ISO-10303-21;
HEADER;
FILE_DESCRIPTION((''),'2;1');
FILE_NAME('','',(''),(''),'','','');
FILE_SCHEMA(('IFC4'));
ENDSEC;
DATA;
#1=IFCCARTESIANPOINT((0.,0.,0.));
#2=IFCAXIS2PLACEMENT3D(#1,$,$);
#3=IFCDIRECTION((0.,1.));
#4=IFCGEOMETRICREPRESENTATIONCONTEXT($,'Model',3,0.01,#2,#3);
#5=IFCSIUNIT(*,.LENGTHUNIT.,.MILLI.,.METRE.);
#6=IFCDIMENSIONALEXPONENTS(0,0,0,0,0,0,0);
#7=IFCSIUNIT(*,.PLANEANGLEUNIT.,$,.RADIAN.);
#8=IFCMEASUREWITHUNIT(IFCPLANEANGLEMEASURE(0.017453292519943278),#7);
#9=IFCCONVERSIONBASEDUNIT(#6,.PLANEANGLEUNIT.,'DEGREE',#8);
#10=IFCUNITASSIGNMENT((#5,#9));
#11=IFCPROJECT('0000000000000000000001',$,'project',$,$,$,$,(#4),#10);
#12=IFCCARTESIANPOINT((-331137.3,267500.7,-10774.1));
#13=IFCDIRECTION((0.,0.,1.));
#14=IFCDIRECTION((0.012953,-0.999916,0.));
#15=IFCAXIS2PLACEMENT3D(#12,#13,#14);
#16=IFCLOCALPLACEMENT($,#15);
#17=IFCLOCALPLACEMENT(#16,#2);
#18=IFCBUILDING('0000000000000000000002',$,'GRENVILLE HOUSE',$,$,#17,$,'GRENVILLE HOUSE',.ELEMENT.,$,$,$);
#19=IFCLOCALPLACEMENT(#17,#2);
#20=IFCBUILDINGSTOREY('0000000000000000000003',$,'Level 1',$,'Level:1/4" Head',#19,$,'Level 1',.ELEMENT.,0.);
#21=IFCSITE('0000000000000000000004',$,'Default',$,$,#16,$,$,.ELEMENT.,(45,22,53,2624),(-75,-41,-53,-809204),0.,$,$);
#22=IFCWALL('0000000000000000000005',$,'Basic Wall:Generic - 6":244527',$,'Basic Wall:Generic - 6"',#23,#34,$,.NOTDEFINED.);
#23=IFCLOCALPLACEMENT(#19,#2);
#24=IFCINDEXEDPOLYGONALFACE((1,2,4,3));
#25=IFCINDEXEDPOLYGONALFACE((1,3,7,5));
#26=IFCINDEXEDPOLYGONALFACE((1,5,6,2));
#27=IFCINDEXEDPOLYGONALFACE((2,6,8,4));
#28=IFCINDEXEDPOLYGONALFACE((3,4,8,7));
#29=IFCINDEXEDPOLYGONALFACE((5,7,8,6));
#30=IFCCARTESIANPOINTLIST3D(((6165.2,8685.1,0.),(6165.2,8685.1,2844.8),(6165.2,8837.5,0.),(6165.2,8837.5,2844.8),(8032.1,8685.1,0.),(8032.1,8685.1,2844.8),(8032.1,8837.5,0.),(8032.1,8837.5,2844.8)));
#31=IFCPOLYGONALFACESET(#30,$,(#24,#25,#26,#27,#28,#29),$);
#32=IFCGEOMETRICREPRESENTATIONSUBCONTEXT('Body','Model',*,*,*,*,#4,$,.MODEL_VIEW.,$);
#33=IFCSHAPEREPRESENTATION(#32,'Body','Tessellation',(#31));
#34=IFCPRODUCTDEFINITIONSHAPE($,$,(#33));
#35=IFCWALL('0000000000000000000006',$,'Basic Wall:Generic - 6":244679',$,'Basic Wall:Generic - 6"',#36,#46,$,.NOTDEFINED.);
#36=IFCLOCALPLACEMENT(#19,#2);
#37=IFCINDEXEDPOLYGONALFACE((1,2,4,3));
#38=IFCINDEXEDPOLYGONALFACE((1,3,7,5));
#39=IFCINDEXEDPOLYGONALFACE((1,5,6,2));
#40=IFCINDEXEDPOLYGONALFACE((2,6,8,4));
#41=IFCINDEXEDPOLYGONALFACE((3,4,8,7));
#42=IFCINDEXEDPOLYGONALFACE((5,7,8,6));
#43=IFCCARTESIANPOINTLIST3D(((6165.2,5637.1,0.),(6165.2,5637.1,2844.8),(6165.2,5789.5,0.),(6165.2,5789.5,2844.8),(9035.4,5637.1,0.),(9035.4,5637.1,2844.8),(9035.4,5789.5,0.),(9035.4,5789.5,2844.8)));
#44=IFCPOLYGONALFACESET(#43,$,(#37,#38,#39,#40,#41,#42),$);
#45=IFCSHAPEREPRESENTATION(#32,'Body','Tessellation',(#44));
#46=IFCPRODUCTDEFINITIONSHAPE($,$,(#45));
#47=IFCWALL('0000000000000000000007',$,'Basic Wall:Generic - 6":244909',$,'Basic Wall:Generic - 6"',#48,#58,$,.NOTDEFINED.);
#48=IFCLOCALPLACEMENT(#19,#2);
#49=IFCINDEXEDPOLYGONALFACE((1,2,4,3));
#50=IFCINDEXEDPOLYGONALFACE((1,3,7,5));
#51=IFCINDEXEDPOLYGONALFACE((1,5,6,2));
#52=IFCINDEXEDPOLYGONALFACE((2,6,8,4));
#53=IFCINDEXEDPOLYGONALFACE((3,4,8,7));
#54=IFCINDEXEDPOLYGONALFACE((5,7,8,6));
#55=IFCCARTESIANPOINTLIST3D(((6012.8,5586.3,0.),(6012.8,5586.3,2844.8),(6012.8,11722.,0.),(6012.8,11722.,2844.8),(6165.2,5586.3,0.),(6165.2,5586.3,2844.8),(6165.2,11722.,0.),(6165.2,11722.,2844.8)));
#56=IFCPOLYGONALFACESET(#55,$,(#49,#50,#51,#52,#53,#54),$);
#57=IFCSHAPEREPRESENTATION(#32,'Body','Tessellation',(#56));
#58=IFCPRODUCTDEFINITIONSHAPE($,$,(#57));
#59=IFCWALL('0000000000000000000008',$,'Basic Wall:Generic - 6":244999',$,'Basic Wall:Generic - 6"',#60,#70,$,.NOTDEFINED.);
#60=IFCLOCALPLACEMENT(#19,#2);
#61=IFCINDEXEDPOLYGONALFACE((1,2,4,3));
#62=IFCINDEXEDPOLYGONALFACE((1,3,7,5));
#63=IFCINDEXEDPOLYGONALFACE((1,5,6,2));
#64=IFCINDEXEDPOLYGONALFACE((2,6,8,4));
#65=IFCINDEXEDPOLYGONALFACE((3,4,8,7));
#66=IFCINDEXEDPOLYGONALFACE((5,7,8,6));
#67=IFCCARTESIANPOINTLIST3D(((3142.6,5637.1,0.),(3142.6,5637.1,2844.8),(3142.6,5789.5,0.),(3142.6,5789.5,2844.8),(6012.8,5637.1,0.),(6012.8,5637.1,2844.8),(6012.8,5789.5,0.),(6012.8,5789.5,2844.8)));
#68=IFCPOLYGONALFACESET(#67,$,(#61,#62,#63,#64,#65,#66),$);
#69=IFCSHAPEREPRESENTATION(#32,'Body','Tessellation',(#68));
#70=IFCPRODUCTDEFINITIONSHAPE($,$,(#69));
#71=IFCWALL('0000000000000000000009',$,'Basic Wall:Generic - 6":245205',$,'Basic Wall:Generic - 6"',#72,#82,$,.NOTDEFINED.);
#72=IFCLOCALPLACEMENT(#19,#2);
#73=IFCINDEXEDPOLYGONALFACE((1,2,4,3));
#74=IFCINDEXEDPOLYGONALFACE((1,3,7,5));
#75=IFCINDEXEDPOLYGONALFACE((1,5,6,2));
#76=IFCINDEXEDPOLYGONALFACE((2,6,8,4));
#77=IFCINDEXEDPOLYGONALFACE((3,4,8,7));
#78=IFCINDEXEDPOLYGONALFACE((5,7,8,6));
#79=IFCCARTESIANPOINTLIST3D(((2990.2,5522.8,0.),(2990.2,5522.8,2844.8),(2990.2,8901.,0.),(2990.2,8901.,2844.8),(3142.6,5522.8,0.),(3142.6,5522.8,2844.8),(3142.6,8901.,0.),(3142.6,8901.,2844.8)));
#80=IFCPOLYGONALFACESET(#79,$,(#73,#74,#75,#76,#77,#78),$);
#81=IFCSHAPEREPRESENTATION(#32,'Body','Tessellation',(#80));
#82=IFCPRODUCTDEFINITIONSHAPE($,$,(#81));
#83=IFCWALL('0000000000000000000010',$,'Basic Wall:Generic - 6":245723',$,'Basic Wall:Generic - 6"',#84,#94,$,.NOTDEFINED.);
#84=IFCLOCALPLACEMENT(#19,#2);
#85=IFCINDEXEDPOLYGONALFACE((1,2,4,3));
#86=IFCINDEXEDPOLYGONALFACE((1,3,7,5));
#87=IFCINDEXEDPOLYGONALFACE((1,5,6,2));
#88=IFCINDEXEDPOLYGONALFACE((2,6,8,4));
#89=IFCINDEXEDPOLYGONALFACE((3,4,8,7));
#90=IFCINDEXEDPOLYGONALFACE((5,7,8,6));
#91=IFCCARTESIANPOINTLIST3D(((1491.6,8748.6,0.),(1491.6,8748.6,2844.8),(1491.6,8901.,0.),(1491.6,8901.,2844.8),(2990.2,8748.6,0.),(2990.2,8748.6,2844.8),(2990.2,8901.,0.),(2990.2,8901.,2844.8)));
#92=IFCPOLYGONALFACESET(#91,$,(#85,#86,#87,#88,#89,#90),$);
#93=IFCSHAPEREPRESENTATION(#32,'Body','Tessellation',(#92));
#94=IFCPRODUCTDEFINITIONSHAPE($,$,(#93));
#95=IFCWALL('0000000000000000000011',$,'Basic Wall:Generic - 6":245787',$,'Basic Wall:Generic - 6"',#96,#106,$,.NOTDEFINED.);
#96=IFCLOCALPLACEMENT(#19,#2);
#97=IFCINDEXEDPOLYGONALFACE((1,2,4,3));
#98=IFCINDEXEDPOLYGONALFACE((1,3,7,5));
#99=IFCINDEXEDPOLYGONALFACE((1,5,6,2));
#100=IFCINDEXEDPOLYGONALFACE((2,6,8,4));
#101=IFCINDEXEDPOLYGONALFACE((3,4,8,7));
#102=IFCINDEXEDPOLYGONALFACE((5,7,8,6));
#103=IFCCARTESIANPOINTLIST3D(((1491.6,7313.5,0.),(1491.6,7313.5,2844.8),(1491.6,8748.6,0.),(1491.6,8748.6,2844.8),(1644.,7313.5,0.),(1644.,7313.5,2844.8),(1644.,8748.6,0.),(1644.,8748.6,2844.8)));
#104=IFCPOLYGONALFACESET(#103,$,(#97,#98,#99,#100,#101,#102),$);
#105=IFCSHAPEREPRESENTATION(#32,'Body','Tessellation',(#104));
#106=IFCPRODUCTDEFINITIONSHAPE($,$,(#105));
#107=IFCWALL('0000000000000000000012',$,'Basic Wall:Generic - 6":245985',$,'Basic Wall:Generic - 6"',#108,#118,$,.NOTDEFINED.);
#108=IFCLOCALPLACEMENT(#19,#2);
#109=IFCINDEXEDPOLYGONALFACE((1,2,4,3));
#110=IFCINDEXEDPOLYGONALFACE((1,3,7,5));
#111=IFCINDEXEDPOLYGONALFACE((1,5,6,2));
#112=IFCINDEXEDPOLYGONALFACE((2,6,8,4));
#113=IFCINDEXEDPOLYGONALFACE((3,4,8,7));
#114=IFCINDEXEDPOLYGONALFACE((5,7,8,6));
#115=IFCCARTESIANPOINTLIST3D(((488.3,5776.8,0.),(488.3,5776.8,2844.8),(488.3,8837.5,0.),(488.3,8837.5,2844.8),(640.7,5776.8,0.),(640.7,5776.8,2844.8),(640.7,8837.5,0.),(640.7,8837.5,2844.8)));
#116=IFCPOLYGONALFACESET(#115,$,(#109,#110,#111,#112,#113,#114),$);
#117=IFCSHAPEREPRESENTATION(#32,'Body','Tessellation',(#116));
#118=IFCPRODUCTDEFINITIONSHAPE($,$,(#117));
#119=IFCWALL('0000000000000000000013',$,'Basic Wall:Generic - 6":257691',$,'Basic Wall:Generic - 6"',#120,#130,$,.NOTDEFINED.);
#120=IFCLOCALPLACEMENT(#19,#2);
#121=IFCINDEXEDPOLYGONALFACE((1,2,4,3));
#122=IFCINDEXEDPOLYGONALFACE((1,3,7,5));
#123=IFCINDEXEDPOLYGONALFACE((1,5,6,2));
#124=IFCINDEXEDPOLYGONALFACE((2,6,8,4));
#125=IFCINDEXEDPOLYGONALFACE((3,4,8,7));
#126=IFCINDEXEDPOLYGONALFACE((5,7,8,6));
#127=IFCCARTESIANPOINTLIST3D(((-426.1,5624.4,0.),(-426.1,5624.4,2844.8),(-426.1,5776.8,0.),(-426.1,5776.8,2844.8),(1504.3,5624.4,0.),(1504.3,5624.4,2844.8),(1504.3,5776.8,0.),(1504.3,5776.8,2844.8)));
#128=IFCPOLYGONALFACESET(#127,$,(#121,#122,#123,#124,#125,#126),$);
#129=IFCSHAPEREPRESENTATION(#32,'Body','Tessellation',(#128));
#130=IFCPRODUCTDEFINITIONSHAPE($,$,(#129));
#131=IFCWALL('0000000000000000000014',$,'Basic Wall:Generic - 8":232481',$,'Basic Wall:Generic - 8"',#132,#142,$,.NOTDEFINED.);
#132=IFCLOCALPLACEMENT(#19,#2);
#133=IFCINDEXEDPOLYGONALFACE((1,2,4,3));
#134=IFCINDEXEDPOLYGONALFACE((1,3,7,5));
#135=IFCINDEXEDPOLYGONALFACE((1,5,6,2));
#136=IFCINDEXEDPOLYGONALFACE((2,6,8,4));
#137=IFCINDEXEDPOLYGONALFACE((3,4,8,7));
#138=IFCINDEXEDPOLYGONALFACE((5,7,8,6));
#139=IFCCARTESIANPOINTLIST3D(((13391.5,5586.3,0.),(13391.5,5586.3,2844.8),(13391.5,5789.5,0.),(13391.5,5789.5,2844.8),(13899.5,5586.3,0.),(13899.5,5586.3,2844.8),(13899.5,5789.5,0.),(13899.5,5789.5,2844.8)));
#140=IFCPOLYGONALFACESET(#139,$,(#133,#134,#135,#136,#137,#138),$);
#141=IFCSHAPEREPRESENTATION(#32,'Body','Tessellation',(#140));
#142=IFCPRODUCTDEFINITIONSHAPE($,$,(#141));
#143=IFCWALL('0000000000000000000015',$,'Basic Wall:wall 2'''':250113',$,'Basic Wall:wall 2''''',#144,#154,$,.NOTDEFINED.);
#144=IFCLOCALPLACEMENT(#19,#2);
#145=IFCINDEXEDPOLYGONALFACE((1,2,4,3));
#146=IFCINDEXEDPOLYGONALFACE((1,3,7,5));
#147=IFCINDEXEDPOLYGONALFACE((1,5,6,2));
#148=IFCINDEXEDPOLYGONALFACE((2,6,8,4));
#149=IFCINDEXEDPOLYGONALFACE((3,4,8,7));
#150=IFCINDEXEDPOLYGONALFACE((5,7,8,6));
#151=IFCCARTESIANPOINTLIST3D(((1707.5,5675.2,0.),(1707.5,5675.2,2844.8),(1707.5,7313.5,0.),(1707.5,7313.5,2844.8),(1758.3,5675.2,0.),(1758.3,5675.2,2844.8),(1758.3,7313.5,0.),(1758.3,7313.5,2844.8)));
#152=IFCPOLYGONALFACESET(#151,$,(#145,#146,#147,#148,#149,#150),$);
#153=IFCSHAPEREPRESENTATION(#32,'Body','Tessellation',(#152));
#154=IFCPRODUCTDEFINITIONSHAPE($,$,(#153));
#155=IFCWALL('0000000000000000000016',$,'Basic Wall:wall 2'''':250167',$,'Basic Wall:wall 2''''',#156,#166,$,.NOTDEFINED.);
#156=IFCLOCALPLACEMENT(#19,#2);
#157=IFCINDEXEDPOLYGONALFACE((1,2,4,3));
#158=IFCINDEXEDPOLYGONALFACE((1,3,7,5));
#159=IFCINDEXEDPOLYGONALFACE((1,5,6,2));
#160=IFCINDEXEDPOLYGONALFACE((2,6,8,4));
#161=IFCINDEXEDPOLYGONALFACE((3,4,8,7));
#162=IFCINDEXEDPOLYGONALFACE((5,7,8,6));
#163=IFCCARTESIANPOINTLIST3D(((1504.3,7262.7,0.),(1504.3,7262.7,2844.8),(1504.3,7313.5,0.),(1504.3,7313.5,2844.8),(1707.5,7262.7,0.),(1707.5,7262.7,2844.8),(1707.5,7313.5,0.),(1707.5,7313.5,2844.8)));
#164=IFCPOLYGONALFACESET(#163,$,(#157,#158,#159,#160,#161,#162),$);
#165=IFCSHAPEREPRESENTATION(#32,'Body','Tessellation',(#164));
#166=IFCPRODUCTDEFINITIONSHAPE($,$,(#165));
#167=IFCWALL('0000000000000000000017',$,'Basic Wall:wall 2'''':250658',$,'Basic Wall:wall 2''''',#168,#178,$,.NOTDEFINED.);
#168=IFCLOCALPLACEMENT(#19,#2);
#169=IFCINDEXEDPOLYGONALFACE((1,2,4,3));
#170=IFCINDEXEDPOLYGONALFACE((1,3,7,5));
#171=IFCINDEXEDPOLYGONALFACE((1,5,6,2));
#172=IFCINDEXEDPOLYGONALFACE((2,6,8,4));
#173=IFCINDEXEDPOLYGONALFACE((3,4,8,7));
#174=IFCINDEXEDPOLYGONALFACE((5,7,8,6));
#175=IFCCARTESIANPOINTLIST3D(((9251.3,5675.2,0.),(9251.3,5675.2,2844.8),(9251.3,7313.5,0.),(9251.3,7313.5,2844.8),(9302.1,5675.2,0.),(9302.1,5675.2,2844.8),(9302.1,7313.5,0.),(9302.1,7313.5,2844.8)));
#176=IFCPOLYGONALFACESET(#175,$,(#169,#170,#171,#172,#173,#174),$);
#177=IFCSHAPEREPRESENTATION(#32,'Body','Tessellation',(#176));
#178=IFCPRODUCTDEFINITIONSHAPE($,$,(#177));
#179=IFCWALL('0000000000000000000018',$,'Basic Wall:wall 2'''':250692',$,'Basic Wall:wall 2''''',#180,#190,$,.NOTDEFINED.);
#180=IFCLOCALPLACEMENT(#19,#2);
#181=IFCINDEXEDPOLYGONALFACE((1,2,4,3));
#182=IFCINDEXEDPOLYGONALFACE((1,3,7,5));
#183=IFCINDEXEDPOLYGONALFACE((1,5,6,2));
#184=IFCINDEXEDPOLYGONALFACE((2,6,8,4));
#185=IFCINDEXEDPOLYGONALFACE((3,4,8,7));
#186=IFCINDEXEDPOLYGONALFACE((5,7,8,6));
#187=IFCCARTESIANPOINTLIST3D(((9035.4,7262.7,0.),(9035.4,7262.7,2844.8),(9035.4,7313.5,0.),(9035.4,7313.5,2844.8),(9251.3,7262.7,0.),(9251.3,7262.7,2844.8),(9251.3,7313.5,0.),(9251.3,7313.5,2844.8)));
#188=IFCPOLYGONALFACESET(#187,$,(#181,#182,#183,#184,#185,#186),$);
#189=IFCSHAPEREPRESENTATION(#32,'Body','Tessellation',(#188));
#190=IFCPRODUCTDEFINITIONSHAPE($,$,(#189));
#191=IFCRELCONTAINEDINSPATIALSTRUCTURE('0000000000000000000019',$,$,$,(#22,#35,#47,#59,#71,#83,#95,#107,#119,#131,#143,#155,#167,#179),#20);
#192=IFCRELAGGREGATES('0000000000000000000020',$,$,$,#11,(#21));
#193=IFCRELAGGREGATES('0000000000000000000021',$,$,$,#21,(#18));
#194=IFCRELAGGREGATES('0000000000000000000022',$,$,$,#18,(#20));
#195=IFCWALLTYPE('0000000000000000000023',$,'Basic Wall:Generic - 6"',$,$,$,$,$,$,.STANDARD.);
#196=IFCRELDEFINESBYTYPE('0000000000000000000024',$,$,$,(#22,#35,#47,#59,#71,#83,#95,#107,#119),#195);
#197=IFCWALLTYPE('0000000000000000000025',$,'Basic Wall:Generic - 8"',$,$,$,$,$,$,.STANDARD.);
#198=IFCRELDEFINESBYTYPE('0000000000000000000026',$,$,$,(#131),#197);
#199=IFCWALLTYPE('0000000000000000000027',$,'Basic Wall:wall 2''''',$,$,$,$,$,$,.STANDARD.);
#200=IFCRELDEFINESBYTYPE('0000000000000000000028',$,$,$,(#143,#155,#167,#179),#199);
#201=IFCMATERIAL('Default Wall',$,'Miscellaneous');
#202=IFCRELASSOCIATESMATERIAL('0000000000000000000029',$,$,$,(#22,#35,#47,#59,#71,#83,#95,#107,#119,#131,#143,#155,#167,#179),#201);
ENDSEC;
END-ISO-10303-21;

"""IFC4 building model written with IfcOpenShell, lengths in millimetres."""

from ifc_helpers import new_model, entity, si_unit, converted_unit, direction, frame, origin, place, context, subcontext, project, spatial, indexed_curve, outline, extrude, material, type_object, element, save


model = new_model("IFC4")

# Units and contexts
model_context = context("Model", 3, precision=0.01, world=origin(), true_north=direction((0.0, 1.0)))
body_context = subcontext(model_context, "Body", "Model", "MODEL_VIEW")
ifc_project = project(units=[si_unit("LENGTHUNIT", "METRE", prefix="MILLI"), converted_unit("PLANEANGLEUNIT", "DEGREE", entity("IfcPlaneAngleMeasure", 0.017453292519943278), si_unit("PLANEANGLEUNIT", "RADIAN"), dimensions=[0, 0, 0, 0, 0, 0, 0])], contexts=[model_context])

# Site, building, storey
site_placement = place(None, frame((-331137.3, 267500.7, -10774.1), z_axis=(0.0, 0.0, 1.0), x_axis=(0.012953, -0.999916, 0.0)))
site = spatial("IfcSite", under=ifc_project, at=site_placement, Name="Default", CompositionType="ELEMENT", RefLatitude=(45, 22, 53, 2624), RefLongitude=(-75, -41, -53, -809204), RefElevation=0.0)
building_placement = place(site_placement, origin())
building = spatial("IfcBuilding", under=site, at=building_placement, Name="GRENVILLE HOUSE", LongName="GRENVILLE HOUSE", CompositionType="ELEMENT")
storey_placement = place(building_placement, origin())
storey = spatial("IfcBuildingStorey", under=building, at=storey_placement, Name="Level 1", ObjectType="Level:1/4\" Head", LongName="Level 1", CompositionType="ELEMENT", Elevation=0.0)

# Walls
ifc_material = material(Name="Default Wall", Category="Miscellaneous")
wall_type_1 = type_object("IfcWallType", Name="Basic Wall:Generic - 6\"", PredefinedType="STANDARD")
wall_1_placement = place(storey_placement, frame((8032.1, 8761.3, 0.0), z_axis=(0.0, 0.0, 1.0), x_axis=(-1.0, 0.0, 0.0)))
element("IfcWall", 1, at=wall_1_placement, inside=storey, type_object=wall_type_1, material=ifc_material, Name="Basic Wall:Generic - 6\":244527", ObjectType="Basic Wall:Generic - 6\"", PredefinedType="NOTDEFINED", context=body_context, shape_type="SweptSolid", body=[
    extrude(outline(indexed_curve([(1866.9, 76.2), (0.0, 76.2), (0.0, -76.2), (1866.9, -76.2), (1866.9, 76.2)], self_intersect=False)), origin(), (0.0, 0.0, 1.0), 2844.8),
])
wall_2_placement = place(storey_placement, frame((9035.4, 5713.3, 0.0), z_axis=(0.0, 0.0, 1.0), x_axis=(-1.0, 0.0, 0.0)))
element("IfcWall", 2, at=wall_2_placement, inside=storey, type_object=wall_type_1, material=ifc_material, Name="Basic Wall:Generic - 6\":244679", ObjectType="Basic Wall:Generic - 6\"", PredefinedType="NOTDEFINED", context=body_context, shape_type="SweptSolid", body=[
    extrude(outline(indexed_curve([(2870.2, 76.2), (0.0, 76.2), (0.0, -76.2), (2870.2, -76.2), (2870.2, 76.2)], self_intersect=False)), origin(), (0.0, 0.0, 1.0), 2844.8),
])
wall_3_placement = place(storey_placement, frame((6089.0, 11722.0, 0.0), z_axis=(0.0, 0.0, 1.0), x_axis=(0.0, -1.0, 0.0)))
element("IfcWall", 3, at=wall_3_placement, inside=storey, type_object=wall_type_1, material=ifc_material, Name="Basic Wall:Generic - 6\":244909", ObjectType="Basic Wall:Generic - 6\"", PredefinedType="NOTDEFINED", context=body_context, shape_type="SweptSolid", body=[
    extrude(outline(indexed_curve([(6135.7, 76.2), (0.0, 76.2), (0.0, -76.2), (6135.7, -76.2), (6135.7, 76.2)], self_intersect=False)), origin(), (0.0, 0.0, 1.0), 2844.8),
])
wall_4_placement = place(storey_placement, frame((6012.8, 5713.3, 0.0), z_axis=(0.0, 0.0, 1.0), x_axis=(-1.0, 0.0, 0.0)))
element("IfcWall", 4, at=wall_4_placement, inside=storey, type_object=wall_type_1, material=ifc_material, Name="Basic Wall:Generic - 6\":244999", ObjectType="Basic Wall:Generic - 6\"", PredefinedType="NOTDEFINED", context=body_context, shape_type="SweptSolid", body=[
    extrude(outline(indexed_curve([(2870.2, 76.2), (0.0, 76.2), (0.0, -76.2), (2870.2, -76.2), (2870.2, 76.2)], self_intersect=False)), origin(), (0.0, 0.0, 1.0), 2844.8),
])
wall_5_placement = place(storey_placement, frame((3066.4, 8901.0, 0.0), z_axis=(0.0, 0.0, 1.0), x_axis=(0.0, -1.0, 0.0)))
element("IfcWall", 5, at=wall_5_placement, inside=storey, type_object=wall_type_1, material=ifc_material, Name="Basic Wall:Generic - 6\":245205", ObjectType="Basic Wall:Generic - 6\"", PredefinedType="NOTDEFINED", context=body_context, shape_type="SweptSolid", body=[
    extrude(outline(indexed_curve([(3378.2, 76.2), (0.0, 76.2), (0.0, -76.2), (3378.2, -76.2), (3378.2, 76.2)], self_intersect=False)), origin(), (0.0, 0.0, 1.0), 2844.8),
])
wall_6_placement = place(storey_placement, frame((2990.2, 8824.8, 0.0), z_axis=(0.0, 0.0, 1.0), x_axis=(-1.0, 0.0, 0.0)))
element("IfcWall", 6, at=wall_6_placement, inside=storey, type_object=wall_type_1, material=ifc_material, Name="Basic Wall:Generic - 6\":245723", ObjectType="Basic Wall:Generic - 6\"", PredefinedType="NOTDEFINED", context=body_context, shape_type="SweptSolid", body=[
    extrude(outline(indexed_curve([(1498.6, 76.2), (0.0, 76.2), (0.0, -76.2), (1498.6, -76.2), (1498.6, 76.2)], self_intersect=False)), origin(), (0.0, 0.0, 1.0), 2844.8),
])
wall_7_placement = place(storey_placement, frame((1567.8, 8748.6, 0.0), z_axis=(0.0, 0.0, 1.0), x_axis=(0.0, -1.0, 0.0)))
element("IfcWall", 7, at=wall_7_placement, inside=storey, type_object=wall_type_1, material=ifc_material, Name="Basic Wall:Generic - 6\":245787", ObjectType="Basic Wall:Generic - 6\"", PredefinedType="NOTDEFINED", context=body_context, shape_type="SweptSolid", body=[
    extrude(outline(indexed_curve([(1435.1, 76.2), (0.0, 76.2), (0.0, -76.2), (1435.1, -76.2), (1435.1, 76.2)], self_intersect=False)), origin(), (0.0, 0.0, 1.0), 2844.8),
])
wall_8_placement = place(storey_placement, frame((564.5, 5776.8, 0.0), z_axis=(0.0, 0.0, 1.0), x_axis=(0.0, 1.0, 0.0)))
element("IfcWall", 8, at=wall_8_placement, inside=storey, type_object=wall_type_1, material=ifc_material, Name="Basic Wall:Generic - 6\":245985", ObjectType="Basic Wall:Generic - 6\"", PredefinedType="NOTDEFINED", context=body_context, shape_type="SweptSolid", body=[
    extrude(outline(indexed_curve([(3060.7, 76.2), (0.0, 76.2), (0.0, -76.2), (3060.7, -76.2), (3060.7, 76.2)], self_intersect=False)), origin(), (0.0, 0.0, 1.0), 2844.8),
])
wall_9_placement = place(storey_placement, frame((1504.3, 5700.6, 0.0), z_axis=(0.0, 0.0, 1.0), x_axis=(-1.0, 0.0, 0.0)))
element("IfcWall", 9, at=wall_9_placement, inside=storey, type_object=wall_type_1, material=ifc_material, Name="Basic Wall:Generic - 6\":257691", ObjectType="Basic Wall:Generic - 6\"", PredefinedType="NOTDEFINED", context=body_context, shape_type="SweptSolid", body=[
    extrude(outline(indexed_curve([(1930.4, 76.2), (0.0, 76.2), (0.0, -76.2), (1930.4, -76.2), (1930.4, 76.2)], self_intersect=False)), origin(), (0.0, 0.0, 1.0), 2844.8),
])
wall_type_2 = type_object("IfcWallType", Name="Basic Wall:Generic - 8\"", PredefinedType="STANDARD")
wall_10_placement = place(storey_placement, frame((13391.5, 5687.9, 0.0)))
element("IfcWall", 10, at=wall_10_placement, inside=storey, type_object=wall_type_2, material=ifc_material, Name="Basic Wall:Generic - 8\":232481", ObjectType="Basic Wall:Generic - 8\"", PredefinedType="NOTDEFINED", context=body_context, shape_type="SweptSolid", body=[
    extrude(outline(indexed_curve([(508.0, 101.6), (0.0, 101.6), (0.0, -101.6), (508.0, -101.6), (508.0, 101.6)], self_intersect=False)), origin(), (0.0, 0.0, 1.0), 2844.8),
])
wall_type_3 = type_object("IfcWallType", Name="Basic Wall:wall 2''", PredefinedType="STANDARD")
wall_11_placement = place(storey_placement, frame((1732.9, 5675.2, 0.0), z_axis=(0.0, 0.0, 1.0), x_axis=(0.0, 1.0, 0.0)))
element("IfcWall", 11, at=wall_11_placement, inside=storey, type_object=wall_type_3, material=ifc_material, Name="Basic Wall:wall 2'':250113", ObjectType="Basic Wall:wall 2''", PredefinedType="NOTDEFINED", context=body_context, shape_type="SweptSolid", body=[
    extrude(outline(indexed_curve([(1638.3, 25.4), (0.0, 25.4), (0.0, -25.4), (1638.3, -25.4), (1638.3, 25.4)], self_intersect=False)), origin(), (0.0, 0.0, 1.0), 2844.8),
])
wall_12_placement = place(storey_placement, frame((1707.5, 7288.1, 0.0), z_axis=(0.0, 0.0, 1.0), x_axis=(-1.0, 0.0, 0.0)))
element("IfcWall", 12, at=wall_12_placement, inside=storey, type_object=wall_type_3, material=ifc_material, Name="Basic Wall:wall 2'':250167", ObjectType="Basic Wall:wall 2''", PredefinedType="NOTDEFINED", context=body_context, shape_type="SweptSolid", body=[
    extrude(outline(indexed_curve([(203.2, 25.4), (0.0, 25.4), (0.0, -25.4), (203.2, -25.4), (203.2, 25.4)], self_intersect=False)), origin(), (0.0, 0.0, 1.0), 2844.8),
])
wall_13_placement = place(storey_placement, frame((9276.7, 5675.2, 0.0), z_axis=(0.0, 0.0, 1.0), x_axis=(0.0, 1.0, 0.0)))
element("IfcWall", 13, at=wall_13_placement, inside=storey, type_object=wall_type_3, material=ifc_material, Name="Basic Wall:wall 2'':250658", ObjectType="Basic Wall:wall 2''", PredefinedType="NOTDEFINED", context=body_context, shape_type="SweptSolid", body=[
    extrude(outline(indexed_curve([(1638.3, 25.4), (0.0, 25.4), (0.0, -25.4), (1638.3, -25.4), (1638.3, 25.4)], self_intersect=False)), origin(), (0.0, 0.0, 1.0), 2844.8),
])
wall_14_placement = place(storey_placement, frame((9251.3, 7288.1, 0.0), z_axis=(0.0, 0.0, 1.0), x_axis=(-1.0, 0.0, 0.0)))
element("IfcWall", 14, at=wall_14_placement, inside=storey, type_object=wall_type_3, material=ifc_material, Name="Basic Wall:wall 2'':250692", ObjectType="Basic Wall:wall 2''", PredefinedType="NOTDEFINED", context=body_context, shape_type="SweptSolid", body=[
    extrude(outline(indexed_curve([(215.9, 25.4), (0.0, 25.4), (0.0, -25.4), (215.9, -25.4), (215.9, 25.4)], self_intersect=False)), origin(), (0.0, 0.0, 1.0), 2844.8),
])

save(model, "model.ifc")
